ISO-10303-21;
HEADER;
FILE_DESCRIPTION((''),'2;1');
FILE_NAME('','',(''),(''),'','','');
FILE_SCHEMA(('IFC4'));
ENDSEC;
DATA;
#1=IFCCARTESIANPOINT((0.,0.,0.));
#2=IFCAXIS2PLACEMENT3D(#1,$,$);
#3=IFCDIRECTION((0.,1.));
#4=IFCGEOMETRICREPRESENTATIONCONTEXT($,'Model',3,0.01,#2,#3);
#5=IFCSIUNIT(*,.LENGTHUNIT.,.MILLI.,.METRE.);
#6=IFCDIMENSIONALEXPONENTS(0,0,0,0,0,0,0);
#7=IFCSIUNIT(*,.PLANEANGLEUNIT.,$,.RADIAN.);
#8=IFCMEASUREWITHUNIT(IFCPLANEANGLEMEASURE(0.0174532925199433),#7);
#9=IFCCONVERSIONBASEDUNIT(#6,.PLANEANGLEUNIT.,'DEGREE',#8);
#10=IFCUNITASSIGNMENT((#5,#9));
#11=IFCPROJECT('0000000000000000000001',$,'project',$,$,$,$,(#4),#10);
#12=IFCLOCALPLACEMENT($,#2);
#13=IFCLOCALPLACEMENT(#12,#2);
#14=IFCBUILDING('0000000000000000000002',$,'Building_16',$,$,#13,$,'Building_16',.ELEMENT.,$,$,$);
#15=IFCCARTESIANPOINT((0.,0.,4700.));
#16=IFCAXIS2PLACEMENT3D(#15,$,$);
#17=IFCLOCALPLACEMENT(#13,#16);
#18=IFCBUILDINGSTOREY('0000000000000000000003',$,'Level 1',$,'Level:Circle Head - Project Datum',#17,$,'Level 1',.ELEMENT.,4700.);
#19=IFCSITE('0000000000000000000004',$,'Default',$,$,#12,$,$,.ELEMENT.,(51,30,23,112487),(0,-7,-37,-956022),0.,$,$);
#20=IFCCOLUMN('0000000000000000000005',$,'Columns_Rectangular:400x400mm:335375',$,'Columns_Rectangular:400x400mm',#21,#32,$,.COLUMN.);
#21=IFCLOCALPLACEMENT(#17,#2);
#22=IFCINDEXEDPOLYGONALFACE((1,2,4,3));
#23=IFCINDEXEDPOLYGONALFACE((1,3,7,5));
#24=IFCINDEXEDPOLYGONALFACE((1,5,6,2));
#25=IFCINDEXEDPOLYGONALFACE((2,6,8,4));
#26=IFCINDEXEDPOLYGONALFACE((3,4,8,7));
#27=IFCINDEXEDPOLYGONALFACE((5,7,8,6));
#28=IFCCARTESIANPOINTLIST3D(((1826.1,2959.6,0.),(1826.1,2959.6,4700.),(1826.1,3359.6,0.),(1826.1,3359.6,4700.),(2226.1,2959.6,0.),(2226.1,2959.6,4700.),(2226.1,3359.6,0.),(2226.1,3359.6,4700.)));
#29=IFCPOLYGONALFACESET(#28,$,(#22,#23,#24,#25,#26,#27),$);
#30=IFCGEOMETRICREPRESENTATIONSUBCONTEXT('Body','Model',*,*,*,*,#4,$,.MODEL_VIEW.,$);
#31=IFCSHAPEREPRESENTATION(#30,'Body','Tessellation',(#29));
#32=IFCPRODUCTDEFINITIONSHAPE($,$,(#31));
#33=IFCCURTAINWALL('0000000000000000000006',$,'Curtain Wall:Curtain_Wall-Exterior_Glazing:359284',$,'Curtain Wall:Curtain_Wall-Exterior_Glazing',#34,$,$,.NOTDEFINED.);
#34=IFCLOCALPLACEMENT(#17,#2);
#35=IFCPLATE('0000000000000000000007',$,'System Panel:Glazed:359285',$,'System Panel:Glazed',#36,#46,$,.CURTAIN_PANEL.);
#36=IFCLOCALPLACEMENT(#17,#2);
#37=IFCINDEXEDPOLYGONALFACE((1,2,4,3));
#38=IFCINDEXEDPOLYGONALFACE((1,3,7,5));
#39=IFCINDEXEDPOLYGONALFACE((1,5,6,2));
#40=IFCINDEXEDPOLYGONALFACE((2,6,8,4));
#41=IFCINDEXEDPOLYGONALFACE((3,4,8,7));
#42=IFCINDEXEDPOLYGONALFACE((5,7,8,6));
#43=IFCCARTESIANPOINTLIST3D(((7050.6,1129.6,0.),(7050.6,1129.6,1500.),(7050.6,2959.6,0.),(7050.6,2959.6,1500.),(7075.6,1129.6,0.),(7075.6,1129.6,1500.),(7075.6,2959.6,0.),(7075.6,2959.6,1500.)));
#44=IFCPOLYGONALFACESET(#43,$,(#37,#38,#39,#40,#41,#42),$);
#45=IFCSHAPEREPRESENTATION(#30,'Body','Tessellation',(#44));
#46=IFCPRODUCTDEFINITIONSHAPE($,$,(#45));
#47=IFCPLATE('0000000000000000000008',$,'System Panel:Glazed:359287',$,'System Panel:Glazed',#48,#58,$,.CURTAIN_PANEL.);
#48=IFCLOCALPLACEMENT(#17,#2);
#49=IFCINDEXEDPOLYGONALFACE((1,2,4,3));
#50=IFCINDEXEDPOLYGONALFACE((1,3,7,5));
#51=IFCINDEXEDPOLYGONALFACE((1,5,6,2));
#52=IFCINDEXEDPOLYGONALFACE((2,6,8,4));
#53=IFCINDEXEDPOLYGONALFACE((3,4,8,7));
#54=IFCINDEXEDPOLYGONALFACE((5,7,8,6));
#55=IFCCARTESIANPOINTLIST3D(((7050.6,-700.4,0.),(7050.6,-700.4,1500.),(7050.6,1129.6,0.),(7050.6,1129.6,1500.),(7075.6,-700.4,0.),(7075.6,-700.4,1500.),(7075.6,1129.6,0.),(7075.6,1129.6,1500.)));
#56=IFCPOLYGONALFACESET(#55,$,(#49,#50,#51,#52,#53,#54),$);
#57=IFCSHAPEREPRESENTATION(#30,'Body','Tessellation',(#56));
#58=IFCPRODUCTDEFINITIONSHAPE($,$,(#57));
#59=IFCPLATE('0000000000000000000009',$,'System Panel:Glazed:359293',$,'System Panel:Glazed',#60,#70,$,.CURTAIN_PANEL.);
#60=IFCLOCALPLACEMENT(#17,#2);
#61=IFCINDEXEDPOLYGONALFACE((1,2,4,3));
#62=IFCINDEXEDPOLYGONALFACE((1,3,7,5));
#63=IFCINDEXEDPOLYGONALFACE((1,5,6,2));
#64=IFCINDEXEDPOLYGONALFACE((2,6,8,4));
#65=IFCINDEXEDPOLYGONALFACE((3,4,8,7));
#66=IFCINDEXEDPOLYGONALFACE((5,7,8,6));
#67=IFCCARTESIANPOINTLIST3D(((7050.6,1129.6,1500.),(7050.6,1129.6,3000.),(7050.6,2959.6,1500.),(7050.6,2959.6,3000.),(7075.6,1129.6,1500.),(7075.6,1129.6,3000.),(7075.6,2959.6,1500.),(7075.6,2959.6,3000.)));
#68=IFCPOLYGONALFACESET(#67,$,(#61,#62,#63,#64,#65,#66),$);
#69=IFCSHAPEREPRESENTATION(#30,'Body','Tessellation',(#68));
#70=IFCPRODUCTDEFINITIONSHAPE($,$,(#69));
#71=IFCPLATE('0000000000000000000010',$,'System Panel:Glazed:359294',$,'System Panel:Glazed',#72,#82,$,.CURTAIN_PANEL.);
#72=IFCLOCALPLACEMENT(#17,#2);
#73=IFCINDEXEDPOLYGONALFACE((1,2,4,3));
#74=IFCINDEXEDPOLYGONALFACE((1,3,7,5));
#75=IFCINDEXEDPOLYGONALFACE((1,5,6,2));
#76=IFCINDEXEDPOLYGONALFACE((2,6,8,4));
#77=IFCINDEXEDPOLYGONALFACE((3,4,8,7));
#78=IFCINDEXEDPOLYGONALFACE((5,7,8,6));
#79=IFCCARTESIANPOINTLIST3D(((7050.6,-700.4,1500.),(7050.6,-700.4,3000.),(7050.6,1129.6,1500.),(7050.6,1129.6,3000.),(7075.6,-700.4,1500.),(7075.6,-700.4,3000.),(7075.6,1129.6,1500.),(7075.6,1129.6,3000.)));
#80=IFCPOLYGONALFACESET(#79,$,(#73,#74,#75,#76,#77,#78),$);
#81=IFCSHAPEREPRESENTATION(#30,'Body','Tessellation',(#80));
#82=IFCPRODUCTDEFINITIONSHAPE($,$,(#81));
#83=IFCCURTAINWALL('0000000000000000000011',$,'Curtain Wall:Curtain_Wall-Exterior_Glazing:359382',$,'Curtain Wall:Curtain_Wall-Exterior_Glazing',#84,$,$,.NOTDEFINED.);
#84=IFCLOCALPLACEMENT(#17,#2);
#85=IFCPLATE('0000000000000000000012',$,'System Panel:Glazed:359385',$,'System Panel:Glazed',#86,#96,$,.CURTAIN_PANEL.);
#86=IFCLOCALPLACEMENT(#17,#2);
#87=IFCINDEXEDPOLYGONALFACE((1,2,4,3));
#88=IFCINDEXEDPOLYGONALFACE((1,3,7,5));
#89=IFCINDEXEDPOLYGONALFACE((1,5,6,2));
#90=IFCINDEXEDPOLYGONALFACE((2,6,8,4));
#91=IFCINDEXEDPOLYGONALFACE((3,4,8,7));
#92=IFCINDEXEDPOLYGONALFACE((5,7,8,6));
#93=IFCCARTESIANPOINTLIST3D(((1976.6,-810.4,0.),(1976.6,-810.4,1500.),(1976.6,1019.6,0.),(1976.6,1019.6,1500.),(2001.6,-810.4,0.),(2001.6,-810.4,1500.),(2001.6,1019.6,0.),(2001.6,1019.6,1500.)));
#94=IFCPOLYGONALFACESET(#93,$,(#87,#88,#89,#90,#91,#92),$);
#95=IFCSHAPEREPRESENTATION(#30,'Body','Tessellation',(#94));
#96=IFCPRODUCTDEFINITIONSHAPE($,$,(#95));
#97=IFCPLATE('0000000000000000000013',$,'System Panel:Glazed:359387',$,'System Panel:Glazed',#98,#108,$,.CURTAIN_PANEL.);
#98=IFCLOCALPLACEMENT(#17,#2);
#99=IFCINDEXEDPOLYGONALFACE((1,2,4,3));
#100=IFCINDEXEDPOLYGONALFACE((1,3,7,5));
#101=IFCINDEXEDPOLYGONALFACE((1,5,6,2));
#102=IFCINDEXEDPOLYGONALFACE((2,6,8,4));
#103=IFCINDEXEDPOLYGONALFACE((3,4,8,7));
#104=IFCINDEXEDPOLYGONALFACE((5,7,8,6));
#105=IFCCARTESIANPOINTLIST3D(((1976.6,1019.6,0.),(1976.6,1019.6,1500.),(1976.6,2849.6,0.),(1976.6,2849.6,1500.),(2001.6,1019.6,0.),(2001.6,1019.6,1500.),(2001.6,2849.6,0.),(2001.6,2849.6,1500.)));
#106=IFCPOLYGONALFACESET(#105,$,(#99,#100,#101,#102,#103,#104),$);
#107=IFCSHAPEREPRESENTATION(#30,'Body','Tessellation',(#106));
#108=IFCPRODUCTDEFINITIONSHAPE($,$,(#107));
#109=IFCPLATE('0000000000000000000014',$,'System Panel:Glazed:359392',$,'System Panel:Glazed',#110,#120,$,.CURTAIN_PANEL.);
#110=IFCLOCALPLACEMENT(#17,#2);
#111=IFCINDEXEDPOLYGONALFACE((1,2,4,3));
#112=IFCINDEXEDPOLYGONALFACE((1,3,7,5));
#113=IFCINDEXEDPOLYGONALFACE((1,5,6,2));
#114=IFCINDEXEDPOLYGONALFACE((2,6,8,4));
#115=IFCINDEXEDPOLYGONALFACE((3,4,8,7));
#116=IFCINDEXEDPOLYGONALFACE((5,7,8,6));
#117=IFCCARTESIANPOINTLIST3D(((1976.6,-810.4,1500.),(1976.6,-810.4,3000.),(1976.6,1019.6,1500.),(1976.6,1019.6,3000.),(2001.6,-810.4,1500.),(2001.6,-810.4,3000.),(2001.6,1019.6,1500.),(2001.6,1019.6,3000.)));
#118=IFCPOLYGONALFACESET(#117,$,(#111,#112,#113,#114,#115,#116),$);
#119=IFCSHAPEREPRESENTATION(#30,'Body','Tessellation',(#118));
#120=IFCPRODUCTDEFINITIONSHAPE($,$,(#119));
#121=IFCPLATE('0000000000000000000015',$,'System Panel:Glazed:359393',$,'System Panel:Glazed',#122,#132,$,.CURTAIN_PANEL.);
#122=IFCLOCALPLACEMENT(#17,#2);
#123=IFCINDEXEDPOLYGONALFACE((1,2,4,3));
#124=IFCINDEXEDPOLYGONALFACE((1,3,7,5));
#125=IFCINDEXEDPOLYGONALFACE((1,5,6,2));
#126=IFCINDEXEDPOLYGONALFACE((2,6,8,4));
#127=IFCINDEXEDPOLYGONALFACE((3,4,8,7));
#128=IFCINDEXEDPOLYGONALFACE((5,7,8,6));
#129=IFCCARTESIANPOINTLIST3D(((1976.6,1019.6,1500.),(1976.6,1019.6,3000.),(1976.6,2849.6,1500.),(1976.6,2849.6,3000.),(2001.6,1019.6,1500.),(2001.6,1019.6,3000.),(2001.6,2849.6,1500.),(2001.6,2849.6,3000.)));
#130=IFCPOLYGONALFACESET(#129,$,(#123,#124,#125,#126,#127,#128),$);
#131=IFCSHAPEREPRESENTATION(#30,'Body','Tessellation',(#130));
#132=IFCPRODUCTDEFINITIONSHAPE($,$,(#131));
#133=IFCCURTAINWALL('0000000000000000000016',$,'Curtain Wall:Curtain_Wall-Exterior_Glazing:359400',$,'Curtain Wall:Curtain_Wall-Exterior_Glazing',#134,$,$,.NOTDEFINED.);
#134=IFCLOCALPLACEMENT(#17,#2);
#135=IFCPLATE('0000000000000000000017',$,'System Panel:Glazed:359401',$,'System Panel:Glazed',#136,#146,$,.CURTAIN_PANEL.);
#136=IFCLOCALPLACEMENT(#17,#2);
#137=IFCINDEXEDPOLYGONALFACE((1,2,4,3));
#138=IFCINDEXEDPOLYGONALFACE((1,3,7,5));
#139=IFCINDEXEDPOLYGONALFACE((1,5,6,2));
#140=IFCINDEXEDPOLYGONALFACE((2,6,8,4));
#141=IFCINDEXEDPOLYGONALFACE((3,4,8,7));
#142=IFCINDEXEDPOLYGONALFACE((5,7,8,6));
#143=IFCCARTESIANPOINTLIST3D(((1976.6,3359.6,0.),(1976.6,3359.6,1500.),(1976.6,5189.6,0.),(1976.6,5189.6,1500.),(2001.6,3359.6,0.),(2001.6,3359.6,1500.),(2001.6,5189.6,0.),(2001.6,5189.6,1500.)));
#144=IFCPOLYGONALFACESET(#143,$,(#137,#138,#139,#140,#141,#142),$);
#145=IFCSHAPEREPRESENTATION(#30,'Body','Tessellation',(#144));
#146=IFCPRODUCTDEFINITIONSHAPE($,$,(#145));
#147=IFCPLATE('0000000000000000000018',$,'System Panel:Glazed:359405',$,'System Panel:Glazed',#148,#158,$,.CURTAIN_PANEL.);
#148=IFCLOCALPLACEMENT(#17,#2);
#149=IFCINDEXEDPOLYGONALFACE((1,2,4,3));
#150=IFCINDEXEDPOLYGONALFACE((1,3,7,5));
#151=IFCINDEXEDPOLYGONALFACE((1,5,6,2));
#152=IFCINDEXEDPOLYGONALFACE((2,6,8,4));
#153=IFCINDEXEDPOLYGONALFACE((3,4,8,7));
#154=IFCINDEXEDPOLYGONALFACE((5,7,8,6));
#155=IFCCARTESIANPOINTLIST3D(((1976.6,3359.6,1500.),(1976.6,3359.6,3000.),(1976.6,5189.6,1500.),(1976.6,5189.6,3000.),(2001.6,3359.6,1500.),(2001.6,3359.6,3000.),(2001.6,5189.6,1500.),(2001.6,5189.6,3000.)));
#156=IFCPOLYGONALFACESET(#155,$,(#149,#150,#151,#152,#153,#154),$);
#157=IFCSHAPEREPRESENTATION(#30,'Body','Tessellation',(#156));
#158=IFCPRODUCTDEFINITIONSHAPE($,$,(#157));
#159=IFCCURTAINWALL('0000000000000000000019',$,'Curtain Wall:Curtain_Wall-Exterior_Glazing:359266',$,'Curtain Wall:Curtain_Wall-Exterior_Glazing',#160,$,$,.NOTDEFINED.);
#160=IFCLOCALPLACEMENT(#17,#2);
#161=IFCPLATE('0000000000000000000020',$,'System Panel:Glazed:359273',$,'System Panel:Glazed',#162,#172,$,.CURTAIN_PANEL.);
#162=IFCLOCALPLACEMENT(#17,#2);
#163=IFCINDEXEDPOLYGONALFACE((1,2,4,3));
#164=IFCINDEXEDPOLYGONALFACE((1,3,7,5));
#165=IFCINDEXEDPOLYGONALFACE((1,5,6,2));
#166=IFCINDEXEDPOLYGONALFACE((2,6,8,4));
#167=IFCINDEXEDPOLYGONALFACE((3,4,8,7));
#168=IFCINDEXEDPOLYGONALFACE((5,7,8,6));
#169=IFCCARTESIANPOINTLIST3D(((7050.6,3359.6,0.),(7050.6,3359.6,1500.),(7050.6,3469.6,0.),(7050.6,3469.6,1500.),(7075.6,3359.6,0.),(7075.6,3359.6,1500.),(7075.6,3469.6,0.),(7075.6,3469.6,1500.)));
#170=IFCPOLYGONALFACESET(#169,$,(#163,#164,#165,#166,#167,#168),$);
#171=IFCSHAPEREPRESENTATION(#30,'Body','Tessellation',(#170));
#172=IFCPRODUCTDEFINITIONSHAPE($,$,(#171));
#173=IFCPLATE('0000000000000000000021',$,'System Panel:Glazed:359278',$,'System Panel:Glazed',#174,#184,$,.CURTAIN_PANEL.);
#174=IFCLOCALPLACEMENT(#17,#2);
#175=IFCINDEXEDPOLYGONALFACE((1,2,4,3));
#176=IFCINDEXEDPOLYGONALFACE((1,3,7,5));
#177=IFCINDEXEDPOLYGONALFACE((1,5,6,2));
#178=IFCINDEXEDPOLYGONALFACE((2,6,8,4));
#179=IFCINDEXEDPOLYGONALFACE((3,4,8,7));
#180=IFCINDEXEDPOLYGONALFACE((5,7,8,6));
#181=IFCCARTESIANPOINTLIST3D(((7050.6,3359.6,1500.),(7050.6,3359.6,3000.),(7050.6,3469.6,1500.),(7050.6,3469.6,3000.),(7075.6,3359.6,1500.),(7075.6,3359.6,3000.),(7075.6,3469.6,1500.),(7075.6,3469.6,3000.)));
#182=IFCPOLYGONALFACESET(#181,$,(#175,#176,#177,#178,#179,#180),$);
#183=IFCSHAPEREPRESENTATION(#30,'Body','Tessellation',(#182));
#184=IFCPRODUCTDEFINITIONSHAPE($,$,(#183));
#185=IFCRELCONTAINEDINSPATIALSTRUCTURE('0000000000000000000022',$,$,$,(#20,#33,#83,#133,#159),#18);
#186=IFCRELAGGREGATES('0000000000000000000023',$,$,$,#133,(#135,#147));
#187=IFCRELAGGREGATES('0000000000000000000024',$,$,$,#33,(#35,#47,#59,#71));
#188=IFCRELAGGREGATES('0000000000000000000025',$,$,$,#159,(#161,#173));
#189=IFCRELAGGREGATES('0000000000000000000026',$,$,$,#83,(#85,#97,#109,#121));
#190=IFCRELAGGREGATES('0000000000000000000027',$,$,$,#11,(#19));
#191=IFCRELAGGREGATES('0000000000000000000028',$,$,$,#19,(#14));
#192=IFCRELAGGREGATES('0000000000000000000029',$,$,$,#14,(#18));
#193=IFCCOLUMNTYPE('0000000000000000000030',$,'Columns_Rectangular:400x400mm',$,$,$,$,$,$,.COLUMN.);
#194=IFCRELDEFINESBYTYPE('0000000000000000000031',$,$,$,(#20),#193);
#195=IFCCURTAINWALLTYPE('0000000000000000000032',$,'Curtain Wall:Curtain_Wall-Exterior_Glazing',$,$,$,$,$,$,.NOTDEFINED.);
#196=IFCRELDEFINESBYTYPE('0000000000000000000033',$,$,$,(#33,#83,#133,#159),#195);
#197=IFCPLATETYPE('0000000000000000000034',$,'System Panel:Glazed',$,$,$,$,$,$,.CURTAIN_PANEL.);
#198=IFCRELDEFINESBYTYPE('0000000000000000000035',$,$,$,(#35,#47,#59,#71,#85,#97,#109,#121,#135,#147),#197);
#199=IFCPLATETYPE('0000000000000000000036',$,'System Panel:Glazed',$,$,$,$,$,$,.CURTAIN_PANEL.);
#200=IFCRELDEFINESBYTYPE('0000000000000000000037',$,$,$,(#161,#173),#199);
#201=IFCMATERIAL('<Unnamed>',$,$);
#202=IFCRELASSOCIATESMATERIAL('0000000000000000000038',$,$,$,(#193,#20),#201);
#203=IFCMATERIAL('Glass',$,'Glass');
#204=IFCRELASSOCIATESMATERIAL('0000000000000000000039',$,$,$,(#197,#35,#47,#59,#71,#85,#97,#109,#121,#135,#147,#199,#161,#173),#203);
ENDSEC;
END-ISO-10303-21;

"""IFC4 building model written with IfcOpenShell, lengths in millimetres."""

from ifc_helpers import new_model, entity, si_unit, converted_unit, direction, frame, origin, place, context, subcontext, project, spatial, indexed_curve, outline, extrude, source, transform, mapped, material, type_object, type_shapes, element, aggregate, save


model = new_model("IFC4")

# Units and contexts
model_context = context("Model", 3, precision=0.01, world=origin(), true_north=direction((0.0, 1.0)))
body_context = subcontext(model_context, "Body", "Model", "MODEL_VIEW")
ifc_project = project(units=[si_unit("LENGTHUNIT", "METRE", prefix="MILLI"), converted_unit("PLANEANGLEUNIT", "DEGREE", entity("IfcPlaneAngleMeasure", 0.0174532925199433), si_unit("PLANEANGLEUNIT", "RADIAN"), dimensions=[0, 0, 0, 0, 0, 0, 0])], contexts=[model_context])

# Site, building, storey
site_placement = place(None, origin())
site = spatial("IfcSite", under=ifc_project, at=site_placement, Name="Default", CompositionType="ELEMENT", RefLatitude=(51, 30, 23, 112487), RefLongitude=(0, -7, -37, -956022), RefElevation=0.0)
building_placement = place(site_placement, origin())
building = spatial("IfcBuilding", under=site, at=building_placement, Name="Building_16", LongName="Building_16", CompositionType="ELEMENT")
storey_placement = place(building_placement, frame((0.0, 0.0, 4700.0)))
storey = spatial("IfcBuildingStorey", under=building, at=storey_placement, Name="Level 1", ObjectType="Level:Circle Head - Project Datum", LongName="Level 1", CompositionType="ELEMENT", Elevation=4700.0)

# Column
ifc_material_1 = material(Name="<Unnamed>")
column_type_1 = type_object("IfcColumnType", Name="Columns_Rectangular:400x400mm", PredefinedType="COLUMN", material=ifc_material_1)
shared_shape_1 = source(origin(), body_context, "Body", "SweptSolid", [
    extrude(outline(indexed_curve([(-200.0, -200.0), (200.0, -200.0), (200.0, 200.0), (-200.0, 200.0), (-200.0, -200.0)], self_intersect=False)), frame((0.0, 0.0, 4700.0), z_axis=(0.0, 0.0, 1.0), x_axis=(-1.0, 0.0, 0.0)), (0.0, 0.0, 1.0), 4700.0),
])
type_shapes(column_type_1, [shared_shape_1])
column_1_placement = place(storey_placement, frame((2026.1, 3159.6, -4700.0)))
element("IfcColumn", 1, at=column_1_placement, inside=storey, type_object=column_type_1, material=ifc_material_1, Name="Columns_Rectangular:400x400mm:335375", ObjectType="Columns_Rectangular:400x400mm", PredefinedType="COLUMN", context=body_context, shape_type="MappedRepresentation", body=[
    mapped(shared_shape_1, transform((0.0, 0.0, 0.0), scale=1.0)),
])

# Curtain walls, plates
curtain_wall_type = type_object("IfcCurtainWallType", Name="Curtain Wall:Curtain_Wall-Exterior_Glazing", PredefinedType="NOTDEFINED")
curtain_wall_1_placement = place(storey_placement, frame((0.0, 0.0, -4700.0)))
curtain_wall_1 = element("IfcCurtainWall", 2, at=curtain_wall_1_placement, inside=storey, type_object=curtain_wall_type, Name="Curtain Wall:Curtain_Wall-Exterior_Glazing:359284", ObjectType="Curtain Wall:Curtain_Wall-Exterior_Glazing", PredefinedType="NOTDEFINED")
ifc_material_2 = material(Name="Glass", Category="Glass")
plate_type_1 = type_object("IfcPlateType", Name="System Panel:Glazed", PredefinedType="CURTAIN_PANEL", material=ifc_material_2)
shared_shape_2 = source(origin(), body_context, "Body", "SweptSolid", [
    extrude(outline(indexed_curve([(-12.5, -915.0), (12.5, -915.0), (12.5, 915.0), (-12.5, 915.0), (-12.5, -915.0)], self_intersect=False)), frame((0.0, 37.0, 0.0), z_axis=(0.0, 0.0, 1.0), x_axis=(0.0, 1.0, 0.0)), (0.0, 0.0, 1.0), 1500.0),
])
type_shapes(plate_type_1, [shared_shape_2])
plate_1_placement = place(curtain_wall_1_placement, frame((7026.1, 2044.6, 4700.0), z_axis=(0.0, 0.0, 1.0), x_axis=(0.0, -1.0, 0.0)))
plate_1 = element("IfcPlate", 3, at=plate_1_placement, type_object=plate_type_1, material=ifc_material_2, Name="System Panel:Glazed:359285", ObjectType="System Panel:Glazed", PredefinedType="CURTAIN_PANEL", context=body_context, shape_type="MappedRepresentation", body=[
    mapped(shared_shape_2, transform((0.0, 0.0, 0.0), scale=1.0)),
])
plate_2_placement = place(curtain_wall_1_placement, frame((7026.1, 214.6, 4700.0), z_axis=(0.0, 0.0, 1.0), x_axis=(0.0, -1.0, 0.0)))
plate_2 = element("IfcPlate", 4, at=plate_2_placement, type_object=plate_type_1, material=ifc_material_2, Name="System Panel:Glazed:359287", ObjectType="System Panel:Glazed", PredefinedType="CURTAIN_PANEL", context=body_context, shape_type="MappedRepresentation", body=[
    mapped(shared_shape_2, transform((0.0, 0.0, 0.0), scale=1.0)),
])
plate_3_placement = place(curtain_wall_1_placement, frame((7026.1, 2044.6, 6200.0), z_axis=(0.0, 0.0, 1.0), x_axis=(0.0, -1.0, 0.0)))
plate_3 = element("IfcPlate", 5, at=plate_3_placement, type_object=plate_type_1, material=ifc_material_2, Name="System Panel:Glazed:359293", ObjectType="System Panel:Glazed", PredefinedType="CURTAIN_PANEL", context=body_context, shape_type="MappedRepresentation", body=[
    mapped(shared_shape_2, transform((0.0, 0.0, 0.0), scale=1.0)),
])
plate_4_placement = place(curtain_wall_1_placement, frame((7026.1, 214.6, 6200.0), z_axis=(0.0, 0.0, 1.0), x_axis=(0.0, -1.0, 0.0)))
plate_4 = element("IfcPlate", 6, at=plate_4_placement, type_object=plate_type_1, material=ifc_material_2, Name="System Panel:Glazed:359294", ObjectType="System Panel:Glazed", PredefinedType="CURTAIN_PANEL", context=body_context, shape_type="MappedRepresentation", body=[
    mapped(shared_shape_2, transform((0.0, 0.0, 0.0), scale=1.0)),
])
curtain_wall_2_placement = place(storey_placement, frame((0.0, 0.0, -4700.0)))
curtain_wall_2 = element("IfcCurtainWall", 7, at=curtain_wall_2_placement, inside=storey, type_object=curtain_wall_type, Name="Curtain Wall:Curtain_Wall-Exterior_Glazing:359382", ObjectType="Curtain Wall:Curtain_Wall-Exterior_Glazing", PredefinedType="NOTDEFINED")
plate_5_placement = place(curtain_wall_2_placement, frame((2026.1, 104.6, 4700.0), z_axis=(0.0, 0.0, 1.0), x_axis=(0.0, 1.0, 0.0)))
plate_5 = element("IfcPlate", 8, at=plate_5_placement, type_object=plate_type_1, material=ifc_material_2, Name="System Panel:Glazed:359385", ObjectType="System Panel:Glazed", PredefinedType="CURTAIN_PANEL", context=body_context, shape_type="MappedRepresentation", body=[
    mapped(shared_shape_2, transform((0.0, 0.0, 0.0), scale=1.0)),
])
plate_6_placement = place(curtain_wall_2_placement, frame((2026.1, 1934.6, 4700.0), z_axis=(0.0, 0.0, 1.0), x_axis=(0.0, 1.0, 0.0)))
plate_6 = element("IfcPlate", 9, at=plate_6_placement, type_object=plate_type_1, material=ifc_material_2, Name="System Panel:Glazed:359387", ObjectType="System Panel:Glazed", PredefinedType="CURTAIN_PANEL", context=body_context, shape_type="MappedRepresentation", body=[
    mapped(shared_shape_2, transform((0.0, 0.0, 0.0), scale=1.0)),
])
plate_7_placement = place(curtain_wall_2_placement, frame((2026.1, 104.6, 6200.0), z_axis=(0.0, 0.0, 1.0), x_axis=(0.0, 1.0, 0.0)))
plate_7 = element("IfcPlate", 10, at=plate_7_placement, type_object=plate_type_1, material=ifc_material_2, Name="System Panel:Glazed:359392", ObjectType="System Panel:Glazed", PredefinedType="CURTAIN_PANEL", context=body_context, shape_type="MappedRepresentation", body=[
    mapped(shared_shape_2, transform((0.0, 0.0, 0.0), scale=1.0)),
])
plate_8_placement = place(curtain_wall_2_placement, frame((2026.1, 1934.6, 6200.0), z_axis=(0.0, 0.0, 1.0), x_axis=(0.0, 1.0, 0.0)))
plate_8 = element("IfcPlate", 11, at=plate_8_placement, type_object=plate_type_1, material=ifc_material_2, Name="System Panel:Glazed:359393", ObjectType="System Panel:Glazed", PredefinedType="CURTAIN_PANEL", context=body_context, shape_type="MappedRepresentation", body=[
    mapped(shared_shape_2, transform((0.0, 0.0, 0.0), scale=1.0)),
])
curtain_wall_3_placement = place(storey_placement, frame((0.0, 0.0, -4700.0)))
curtain_wall_3 = element("IfcCurtainWall", 12, at=curtain_wall_3_placement, inside=storey, type_object=curtain_wall_type, Name="Curtain Wall:Curtain_Wall-Exterior_Glazing:359400", ObjectType="Curtain Wall:Curtain_Wall-Exterior_Glazing", PredefinedType="NOTDEFINED")
plate_9_placement = place(curtain_wall_3_placement, frame((2026.1, 4274.6, 4700.0), z_axis=(0.0, 0.0, 1.0), x_axis=(0.0, 1.0, 0.0)))
plate_9 = element("IfcPlate", 13, at=plate_9_placement, type_object=plate_type_1, material=ifc_material_2, Name="System Panel:Glazed:359401", ObjectType="System Panel:Glazed", PredefinedType="CURTAIN_PANEL", context=body_context, shape_type="MappedRepresentation", body=[
    mapped(shared_shape_2, transform((0.0, 0.0, 0.0), scale=1.0)),
])
plate_10_placement = place(curtain_wall_3_placement, frame((2026.1, 4274.6, 6200.0), z_axis=(0.0, 0.0, 1.0), x_axis=(0.0, 1.0, 0.0)))
plate_10 = element("IfcPlate", 14, at=plate_10_placement, type_object=plate_type_1, material=ifc_material_2, Name="System Panel:Glazed:359405", ObjectType="System Panel:Glazed", PredefinedType="CURTAIN_PANEL", context=body_context, shape_type="MappedRepresentation", body=[
    mapped(shared_shape_2, transform((0.0, 0.0, 0.0), scale=1.0)),
])
aggregate(curtain_wall_3, [plate_9, plate_10])
curtain_wall_4_placement = place(storey_placement, frame((0.0, 0.0, -4700.0)))
curtain_wall_4 = element("IfcCurtainWall", 15, at=curtain_wall_4_placement, inside=storey, type_object=curtain_wall_type, Name="Curtain Wall:Curtain_Wall-Exterior_Glazing:359266", ObjectType="Curtain Wall:Curtain_Wall-Exterior_Glazing", PredefinedType="NOTDEFINED")
plate_type_2 = type_object("IfcPlateType", Name="System Panel:Glazed", PredefinedType="CURTAIN_PANEL", material=ifc_material_2)
shared_shape_3 = source(origin(), body_context, "Body", "SweptSolid", [
    extrude(outline(indexed_curve([(-12.5, -55.0), (12.5, -55.0), (12.5, 55.0), (-12.5, 55.0), (-12.5, -55.0)], self_intersect=False)), frame((0.0, 37.0, 0.0), z_axis=(0.0, 0.0, 1.0), x_axis=(0.0, 1.0, 0.0)), (0.0, 0.0, 1.0), 1500.0),
])
type_shapes(plate_type_2, [shared_shape_3])
plate_11_placement = place(curtain_wall_4_placement, frame((7026.1, 3414.6, 4700.0), z_axis=(0.0, 0.0, 1.0), x_axis=(0.0, -1.0, 0.0)))
plate_11 = element("IfcPlate", 16, at=plate_11_placement, type_object=plate_type_2, material=ifc_material_2, Name="System Panel:Glazed:359273", ObjectType="System Panel:Glazed", PredefinedType="CURTAIN_PANEL", context=body_context, shape_type="MappedRepresentation", body=[
    mapped(shared_shape_3, transform((0.0, 0.0, 0.0), scale=1.0)),
])
plate_12_placement = place(curtain_wall_4_placement, frame((7026.1, 3414.6, 6200.0), z_axis=(0.0, 0.0, 1.0), x_axis=(0.0, -1.0, 0.0)))
plate_12 = element("IfcPlate", 17, at=plate_12_placement, type_object=plate_type_2, material=ifc_material_2, Name="System Panel:Glazed:359278", ObjectType="System Panel:Glazed", PredefinedType="CURTAIN_PANEL", context=body_context, shape_type="MappedRepresentation", body=[
    mapped(shared_shape_3, transform((0.0, 0.0, 0.0), scale=1.0)),
])

aggregate(curtain_wall_1, [plate_1, plate_2, plate_3, plate_4])
aggregate(curtain_wall_4, [plate_11, plate_12])
aggregate(curtain_wall_2, [plate_5, plate_6, plate_7, plate_8])

save(model, "model.ifc")
